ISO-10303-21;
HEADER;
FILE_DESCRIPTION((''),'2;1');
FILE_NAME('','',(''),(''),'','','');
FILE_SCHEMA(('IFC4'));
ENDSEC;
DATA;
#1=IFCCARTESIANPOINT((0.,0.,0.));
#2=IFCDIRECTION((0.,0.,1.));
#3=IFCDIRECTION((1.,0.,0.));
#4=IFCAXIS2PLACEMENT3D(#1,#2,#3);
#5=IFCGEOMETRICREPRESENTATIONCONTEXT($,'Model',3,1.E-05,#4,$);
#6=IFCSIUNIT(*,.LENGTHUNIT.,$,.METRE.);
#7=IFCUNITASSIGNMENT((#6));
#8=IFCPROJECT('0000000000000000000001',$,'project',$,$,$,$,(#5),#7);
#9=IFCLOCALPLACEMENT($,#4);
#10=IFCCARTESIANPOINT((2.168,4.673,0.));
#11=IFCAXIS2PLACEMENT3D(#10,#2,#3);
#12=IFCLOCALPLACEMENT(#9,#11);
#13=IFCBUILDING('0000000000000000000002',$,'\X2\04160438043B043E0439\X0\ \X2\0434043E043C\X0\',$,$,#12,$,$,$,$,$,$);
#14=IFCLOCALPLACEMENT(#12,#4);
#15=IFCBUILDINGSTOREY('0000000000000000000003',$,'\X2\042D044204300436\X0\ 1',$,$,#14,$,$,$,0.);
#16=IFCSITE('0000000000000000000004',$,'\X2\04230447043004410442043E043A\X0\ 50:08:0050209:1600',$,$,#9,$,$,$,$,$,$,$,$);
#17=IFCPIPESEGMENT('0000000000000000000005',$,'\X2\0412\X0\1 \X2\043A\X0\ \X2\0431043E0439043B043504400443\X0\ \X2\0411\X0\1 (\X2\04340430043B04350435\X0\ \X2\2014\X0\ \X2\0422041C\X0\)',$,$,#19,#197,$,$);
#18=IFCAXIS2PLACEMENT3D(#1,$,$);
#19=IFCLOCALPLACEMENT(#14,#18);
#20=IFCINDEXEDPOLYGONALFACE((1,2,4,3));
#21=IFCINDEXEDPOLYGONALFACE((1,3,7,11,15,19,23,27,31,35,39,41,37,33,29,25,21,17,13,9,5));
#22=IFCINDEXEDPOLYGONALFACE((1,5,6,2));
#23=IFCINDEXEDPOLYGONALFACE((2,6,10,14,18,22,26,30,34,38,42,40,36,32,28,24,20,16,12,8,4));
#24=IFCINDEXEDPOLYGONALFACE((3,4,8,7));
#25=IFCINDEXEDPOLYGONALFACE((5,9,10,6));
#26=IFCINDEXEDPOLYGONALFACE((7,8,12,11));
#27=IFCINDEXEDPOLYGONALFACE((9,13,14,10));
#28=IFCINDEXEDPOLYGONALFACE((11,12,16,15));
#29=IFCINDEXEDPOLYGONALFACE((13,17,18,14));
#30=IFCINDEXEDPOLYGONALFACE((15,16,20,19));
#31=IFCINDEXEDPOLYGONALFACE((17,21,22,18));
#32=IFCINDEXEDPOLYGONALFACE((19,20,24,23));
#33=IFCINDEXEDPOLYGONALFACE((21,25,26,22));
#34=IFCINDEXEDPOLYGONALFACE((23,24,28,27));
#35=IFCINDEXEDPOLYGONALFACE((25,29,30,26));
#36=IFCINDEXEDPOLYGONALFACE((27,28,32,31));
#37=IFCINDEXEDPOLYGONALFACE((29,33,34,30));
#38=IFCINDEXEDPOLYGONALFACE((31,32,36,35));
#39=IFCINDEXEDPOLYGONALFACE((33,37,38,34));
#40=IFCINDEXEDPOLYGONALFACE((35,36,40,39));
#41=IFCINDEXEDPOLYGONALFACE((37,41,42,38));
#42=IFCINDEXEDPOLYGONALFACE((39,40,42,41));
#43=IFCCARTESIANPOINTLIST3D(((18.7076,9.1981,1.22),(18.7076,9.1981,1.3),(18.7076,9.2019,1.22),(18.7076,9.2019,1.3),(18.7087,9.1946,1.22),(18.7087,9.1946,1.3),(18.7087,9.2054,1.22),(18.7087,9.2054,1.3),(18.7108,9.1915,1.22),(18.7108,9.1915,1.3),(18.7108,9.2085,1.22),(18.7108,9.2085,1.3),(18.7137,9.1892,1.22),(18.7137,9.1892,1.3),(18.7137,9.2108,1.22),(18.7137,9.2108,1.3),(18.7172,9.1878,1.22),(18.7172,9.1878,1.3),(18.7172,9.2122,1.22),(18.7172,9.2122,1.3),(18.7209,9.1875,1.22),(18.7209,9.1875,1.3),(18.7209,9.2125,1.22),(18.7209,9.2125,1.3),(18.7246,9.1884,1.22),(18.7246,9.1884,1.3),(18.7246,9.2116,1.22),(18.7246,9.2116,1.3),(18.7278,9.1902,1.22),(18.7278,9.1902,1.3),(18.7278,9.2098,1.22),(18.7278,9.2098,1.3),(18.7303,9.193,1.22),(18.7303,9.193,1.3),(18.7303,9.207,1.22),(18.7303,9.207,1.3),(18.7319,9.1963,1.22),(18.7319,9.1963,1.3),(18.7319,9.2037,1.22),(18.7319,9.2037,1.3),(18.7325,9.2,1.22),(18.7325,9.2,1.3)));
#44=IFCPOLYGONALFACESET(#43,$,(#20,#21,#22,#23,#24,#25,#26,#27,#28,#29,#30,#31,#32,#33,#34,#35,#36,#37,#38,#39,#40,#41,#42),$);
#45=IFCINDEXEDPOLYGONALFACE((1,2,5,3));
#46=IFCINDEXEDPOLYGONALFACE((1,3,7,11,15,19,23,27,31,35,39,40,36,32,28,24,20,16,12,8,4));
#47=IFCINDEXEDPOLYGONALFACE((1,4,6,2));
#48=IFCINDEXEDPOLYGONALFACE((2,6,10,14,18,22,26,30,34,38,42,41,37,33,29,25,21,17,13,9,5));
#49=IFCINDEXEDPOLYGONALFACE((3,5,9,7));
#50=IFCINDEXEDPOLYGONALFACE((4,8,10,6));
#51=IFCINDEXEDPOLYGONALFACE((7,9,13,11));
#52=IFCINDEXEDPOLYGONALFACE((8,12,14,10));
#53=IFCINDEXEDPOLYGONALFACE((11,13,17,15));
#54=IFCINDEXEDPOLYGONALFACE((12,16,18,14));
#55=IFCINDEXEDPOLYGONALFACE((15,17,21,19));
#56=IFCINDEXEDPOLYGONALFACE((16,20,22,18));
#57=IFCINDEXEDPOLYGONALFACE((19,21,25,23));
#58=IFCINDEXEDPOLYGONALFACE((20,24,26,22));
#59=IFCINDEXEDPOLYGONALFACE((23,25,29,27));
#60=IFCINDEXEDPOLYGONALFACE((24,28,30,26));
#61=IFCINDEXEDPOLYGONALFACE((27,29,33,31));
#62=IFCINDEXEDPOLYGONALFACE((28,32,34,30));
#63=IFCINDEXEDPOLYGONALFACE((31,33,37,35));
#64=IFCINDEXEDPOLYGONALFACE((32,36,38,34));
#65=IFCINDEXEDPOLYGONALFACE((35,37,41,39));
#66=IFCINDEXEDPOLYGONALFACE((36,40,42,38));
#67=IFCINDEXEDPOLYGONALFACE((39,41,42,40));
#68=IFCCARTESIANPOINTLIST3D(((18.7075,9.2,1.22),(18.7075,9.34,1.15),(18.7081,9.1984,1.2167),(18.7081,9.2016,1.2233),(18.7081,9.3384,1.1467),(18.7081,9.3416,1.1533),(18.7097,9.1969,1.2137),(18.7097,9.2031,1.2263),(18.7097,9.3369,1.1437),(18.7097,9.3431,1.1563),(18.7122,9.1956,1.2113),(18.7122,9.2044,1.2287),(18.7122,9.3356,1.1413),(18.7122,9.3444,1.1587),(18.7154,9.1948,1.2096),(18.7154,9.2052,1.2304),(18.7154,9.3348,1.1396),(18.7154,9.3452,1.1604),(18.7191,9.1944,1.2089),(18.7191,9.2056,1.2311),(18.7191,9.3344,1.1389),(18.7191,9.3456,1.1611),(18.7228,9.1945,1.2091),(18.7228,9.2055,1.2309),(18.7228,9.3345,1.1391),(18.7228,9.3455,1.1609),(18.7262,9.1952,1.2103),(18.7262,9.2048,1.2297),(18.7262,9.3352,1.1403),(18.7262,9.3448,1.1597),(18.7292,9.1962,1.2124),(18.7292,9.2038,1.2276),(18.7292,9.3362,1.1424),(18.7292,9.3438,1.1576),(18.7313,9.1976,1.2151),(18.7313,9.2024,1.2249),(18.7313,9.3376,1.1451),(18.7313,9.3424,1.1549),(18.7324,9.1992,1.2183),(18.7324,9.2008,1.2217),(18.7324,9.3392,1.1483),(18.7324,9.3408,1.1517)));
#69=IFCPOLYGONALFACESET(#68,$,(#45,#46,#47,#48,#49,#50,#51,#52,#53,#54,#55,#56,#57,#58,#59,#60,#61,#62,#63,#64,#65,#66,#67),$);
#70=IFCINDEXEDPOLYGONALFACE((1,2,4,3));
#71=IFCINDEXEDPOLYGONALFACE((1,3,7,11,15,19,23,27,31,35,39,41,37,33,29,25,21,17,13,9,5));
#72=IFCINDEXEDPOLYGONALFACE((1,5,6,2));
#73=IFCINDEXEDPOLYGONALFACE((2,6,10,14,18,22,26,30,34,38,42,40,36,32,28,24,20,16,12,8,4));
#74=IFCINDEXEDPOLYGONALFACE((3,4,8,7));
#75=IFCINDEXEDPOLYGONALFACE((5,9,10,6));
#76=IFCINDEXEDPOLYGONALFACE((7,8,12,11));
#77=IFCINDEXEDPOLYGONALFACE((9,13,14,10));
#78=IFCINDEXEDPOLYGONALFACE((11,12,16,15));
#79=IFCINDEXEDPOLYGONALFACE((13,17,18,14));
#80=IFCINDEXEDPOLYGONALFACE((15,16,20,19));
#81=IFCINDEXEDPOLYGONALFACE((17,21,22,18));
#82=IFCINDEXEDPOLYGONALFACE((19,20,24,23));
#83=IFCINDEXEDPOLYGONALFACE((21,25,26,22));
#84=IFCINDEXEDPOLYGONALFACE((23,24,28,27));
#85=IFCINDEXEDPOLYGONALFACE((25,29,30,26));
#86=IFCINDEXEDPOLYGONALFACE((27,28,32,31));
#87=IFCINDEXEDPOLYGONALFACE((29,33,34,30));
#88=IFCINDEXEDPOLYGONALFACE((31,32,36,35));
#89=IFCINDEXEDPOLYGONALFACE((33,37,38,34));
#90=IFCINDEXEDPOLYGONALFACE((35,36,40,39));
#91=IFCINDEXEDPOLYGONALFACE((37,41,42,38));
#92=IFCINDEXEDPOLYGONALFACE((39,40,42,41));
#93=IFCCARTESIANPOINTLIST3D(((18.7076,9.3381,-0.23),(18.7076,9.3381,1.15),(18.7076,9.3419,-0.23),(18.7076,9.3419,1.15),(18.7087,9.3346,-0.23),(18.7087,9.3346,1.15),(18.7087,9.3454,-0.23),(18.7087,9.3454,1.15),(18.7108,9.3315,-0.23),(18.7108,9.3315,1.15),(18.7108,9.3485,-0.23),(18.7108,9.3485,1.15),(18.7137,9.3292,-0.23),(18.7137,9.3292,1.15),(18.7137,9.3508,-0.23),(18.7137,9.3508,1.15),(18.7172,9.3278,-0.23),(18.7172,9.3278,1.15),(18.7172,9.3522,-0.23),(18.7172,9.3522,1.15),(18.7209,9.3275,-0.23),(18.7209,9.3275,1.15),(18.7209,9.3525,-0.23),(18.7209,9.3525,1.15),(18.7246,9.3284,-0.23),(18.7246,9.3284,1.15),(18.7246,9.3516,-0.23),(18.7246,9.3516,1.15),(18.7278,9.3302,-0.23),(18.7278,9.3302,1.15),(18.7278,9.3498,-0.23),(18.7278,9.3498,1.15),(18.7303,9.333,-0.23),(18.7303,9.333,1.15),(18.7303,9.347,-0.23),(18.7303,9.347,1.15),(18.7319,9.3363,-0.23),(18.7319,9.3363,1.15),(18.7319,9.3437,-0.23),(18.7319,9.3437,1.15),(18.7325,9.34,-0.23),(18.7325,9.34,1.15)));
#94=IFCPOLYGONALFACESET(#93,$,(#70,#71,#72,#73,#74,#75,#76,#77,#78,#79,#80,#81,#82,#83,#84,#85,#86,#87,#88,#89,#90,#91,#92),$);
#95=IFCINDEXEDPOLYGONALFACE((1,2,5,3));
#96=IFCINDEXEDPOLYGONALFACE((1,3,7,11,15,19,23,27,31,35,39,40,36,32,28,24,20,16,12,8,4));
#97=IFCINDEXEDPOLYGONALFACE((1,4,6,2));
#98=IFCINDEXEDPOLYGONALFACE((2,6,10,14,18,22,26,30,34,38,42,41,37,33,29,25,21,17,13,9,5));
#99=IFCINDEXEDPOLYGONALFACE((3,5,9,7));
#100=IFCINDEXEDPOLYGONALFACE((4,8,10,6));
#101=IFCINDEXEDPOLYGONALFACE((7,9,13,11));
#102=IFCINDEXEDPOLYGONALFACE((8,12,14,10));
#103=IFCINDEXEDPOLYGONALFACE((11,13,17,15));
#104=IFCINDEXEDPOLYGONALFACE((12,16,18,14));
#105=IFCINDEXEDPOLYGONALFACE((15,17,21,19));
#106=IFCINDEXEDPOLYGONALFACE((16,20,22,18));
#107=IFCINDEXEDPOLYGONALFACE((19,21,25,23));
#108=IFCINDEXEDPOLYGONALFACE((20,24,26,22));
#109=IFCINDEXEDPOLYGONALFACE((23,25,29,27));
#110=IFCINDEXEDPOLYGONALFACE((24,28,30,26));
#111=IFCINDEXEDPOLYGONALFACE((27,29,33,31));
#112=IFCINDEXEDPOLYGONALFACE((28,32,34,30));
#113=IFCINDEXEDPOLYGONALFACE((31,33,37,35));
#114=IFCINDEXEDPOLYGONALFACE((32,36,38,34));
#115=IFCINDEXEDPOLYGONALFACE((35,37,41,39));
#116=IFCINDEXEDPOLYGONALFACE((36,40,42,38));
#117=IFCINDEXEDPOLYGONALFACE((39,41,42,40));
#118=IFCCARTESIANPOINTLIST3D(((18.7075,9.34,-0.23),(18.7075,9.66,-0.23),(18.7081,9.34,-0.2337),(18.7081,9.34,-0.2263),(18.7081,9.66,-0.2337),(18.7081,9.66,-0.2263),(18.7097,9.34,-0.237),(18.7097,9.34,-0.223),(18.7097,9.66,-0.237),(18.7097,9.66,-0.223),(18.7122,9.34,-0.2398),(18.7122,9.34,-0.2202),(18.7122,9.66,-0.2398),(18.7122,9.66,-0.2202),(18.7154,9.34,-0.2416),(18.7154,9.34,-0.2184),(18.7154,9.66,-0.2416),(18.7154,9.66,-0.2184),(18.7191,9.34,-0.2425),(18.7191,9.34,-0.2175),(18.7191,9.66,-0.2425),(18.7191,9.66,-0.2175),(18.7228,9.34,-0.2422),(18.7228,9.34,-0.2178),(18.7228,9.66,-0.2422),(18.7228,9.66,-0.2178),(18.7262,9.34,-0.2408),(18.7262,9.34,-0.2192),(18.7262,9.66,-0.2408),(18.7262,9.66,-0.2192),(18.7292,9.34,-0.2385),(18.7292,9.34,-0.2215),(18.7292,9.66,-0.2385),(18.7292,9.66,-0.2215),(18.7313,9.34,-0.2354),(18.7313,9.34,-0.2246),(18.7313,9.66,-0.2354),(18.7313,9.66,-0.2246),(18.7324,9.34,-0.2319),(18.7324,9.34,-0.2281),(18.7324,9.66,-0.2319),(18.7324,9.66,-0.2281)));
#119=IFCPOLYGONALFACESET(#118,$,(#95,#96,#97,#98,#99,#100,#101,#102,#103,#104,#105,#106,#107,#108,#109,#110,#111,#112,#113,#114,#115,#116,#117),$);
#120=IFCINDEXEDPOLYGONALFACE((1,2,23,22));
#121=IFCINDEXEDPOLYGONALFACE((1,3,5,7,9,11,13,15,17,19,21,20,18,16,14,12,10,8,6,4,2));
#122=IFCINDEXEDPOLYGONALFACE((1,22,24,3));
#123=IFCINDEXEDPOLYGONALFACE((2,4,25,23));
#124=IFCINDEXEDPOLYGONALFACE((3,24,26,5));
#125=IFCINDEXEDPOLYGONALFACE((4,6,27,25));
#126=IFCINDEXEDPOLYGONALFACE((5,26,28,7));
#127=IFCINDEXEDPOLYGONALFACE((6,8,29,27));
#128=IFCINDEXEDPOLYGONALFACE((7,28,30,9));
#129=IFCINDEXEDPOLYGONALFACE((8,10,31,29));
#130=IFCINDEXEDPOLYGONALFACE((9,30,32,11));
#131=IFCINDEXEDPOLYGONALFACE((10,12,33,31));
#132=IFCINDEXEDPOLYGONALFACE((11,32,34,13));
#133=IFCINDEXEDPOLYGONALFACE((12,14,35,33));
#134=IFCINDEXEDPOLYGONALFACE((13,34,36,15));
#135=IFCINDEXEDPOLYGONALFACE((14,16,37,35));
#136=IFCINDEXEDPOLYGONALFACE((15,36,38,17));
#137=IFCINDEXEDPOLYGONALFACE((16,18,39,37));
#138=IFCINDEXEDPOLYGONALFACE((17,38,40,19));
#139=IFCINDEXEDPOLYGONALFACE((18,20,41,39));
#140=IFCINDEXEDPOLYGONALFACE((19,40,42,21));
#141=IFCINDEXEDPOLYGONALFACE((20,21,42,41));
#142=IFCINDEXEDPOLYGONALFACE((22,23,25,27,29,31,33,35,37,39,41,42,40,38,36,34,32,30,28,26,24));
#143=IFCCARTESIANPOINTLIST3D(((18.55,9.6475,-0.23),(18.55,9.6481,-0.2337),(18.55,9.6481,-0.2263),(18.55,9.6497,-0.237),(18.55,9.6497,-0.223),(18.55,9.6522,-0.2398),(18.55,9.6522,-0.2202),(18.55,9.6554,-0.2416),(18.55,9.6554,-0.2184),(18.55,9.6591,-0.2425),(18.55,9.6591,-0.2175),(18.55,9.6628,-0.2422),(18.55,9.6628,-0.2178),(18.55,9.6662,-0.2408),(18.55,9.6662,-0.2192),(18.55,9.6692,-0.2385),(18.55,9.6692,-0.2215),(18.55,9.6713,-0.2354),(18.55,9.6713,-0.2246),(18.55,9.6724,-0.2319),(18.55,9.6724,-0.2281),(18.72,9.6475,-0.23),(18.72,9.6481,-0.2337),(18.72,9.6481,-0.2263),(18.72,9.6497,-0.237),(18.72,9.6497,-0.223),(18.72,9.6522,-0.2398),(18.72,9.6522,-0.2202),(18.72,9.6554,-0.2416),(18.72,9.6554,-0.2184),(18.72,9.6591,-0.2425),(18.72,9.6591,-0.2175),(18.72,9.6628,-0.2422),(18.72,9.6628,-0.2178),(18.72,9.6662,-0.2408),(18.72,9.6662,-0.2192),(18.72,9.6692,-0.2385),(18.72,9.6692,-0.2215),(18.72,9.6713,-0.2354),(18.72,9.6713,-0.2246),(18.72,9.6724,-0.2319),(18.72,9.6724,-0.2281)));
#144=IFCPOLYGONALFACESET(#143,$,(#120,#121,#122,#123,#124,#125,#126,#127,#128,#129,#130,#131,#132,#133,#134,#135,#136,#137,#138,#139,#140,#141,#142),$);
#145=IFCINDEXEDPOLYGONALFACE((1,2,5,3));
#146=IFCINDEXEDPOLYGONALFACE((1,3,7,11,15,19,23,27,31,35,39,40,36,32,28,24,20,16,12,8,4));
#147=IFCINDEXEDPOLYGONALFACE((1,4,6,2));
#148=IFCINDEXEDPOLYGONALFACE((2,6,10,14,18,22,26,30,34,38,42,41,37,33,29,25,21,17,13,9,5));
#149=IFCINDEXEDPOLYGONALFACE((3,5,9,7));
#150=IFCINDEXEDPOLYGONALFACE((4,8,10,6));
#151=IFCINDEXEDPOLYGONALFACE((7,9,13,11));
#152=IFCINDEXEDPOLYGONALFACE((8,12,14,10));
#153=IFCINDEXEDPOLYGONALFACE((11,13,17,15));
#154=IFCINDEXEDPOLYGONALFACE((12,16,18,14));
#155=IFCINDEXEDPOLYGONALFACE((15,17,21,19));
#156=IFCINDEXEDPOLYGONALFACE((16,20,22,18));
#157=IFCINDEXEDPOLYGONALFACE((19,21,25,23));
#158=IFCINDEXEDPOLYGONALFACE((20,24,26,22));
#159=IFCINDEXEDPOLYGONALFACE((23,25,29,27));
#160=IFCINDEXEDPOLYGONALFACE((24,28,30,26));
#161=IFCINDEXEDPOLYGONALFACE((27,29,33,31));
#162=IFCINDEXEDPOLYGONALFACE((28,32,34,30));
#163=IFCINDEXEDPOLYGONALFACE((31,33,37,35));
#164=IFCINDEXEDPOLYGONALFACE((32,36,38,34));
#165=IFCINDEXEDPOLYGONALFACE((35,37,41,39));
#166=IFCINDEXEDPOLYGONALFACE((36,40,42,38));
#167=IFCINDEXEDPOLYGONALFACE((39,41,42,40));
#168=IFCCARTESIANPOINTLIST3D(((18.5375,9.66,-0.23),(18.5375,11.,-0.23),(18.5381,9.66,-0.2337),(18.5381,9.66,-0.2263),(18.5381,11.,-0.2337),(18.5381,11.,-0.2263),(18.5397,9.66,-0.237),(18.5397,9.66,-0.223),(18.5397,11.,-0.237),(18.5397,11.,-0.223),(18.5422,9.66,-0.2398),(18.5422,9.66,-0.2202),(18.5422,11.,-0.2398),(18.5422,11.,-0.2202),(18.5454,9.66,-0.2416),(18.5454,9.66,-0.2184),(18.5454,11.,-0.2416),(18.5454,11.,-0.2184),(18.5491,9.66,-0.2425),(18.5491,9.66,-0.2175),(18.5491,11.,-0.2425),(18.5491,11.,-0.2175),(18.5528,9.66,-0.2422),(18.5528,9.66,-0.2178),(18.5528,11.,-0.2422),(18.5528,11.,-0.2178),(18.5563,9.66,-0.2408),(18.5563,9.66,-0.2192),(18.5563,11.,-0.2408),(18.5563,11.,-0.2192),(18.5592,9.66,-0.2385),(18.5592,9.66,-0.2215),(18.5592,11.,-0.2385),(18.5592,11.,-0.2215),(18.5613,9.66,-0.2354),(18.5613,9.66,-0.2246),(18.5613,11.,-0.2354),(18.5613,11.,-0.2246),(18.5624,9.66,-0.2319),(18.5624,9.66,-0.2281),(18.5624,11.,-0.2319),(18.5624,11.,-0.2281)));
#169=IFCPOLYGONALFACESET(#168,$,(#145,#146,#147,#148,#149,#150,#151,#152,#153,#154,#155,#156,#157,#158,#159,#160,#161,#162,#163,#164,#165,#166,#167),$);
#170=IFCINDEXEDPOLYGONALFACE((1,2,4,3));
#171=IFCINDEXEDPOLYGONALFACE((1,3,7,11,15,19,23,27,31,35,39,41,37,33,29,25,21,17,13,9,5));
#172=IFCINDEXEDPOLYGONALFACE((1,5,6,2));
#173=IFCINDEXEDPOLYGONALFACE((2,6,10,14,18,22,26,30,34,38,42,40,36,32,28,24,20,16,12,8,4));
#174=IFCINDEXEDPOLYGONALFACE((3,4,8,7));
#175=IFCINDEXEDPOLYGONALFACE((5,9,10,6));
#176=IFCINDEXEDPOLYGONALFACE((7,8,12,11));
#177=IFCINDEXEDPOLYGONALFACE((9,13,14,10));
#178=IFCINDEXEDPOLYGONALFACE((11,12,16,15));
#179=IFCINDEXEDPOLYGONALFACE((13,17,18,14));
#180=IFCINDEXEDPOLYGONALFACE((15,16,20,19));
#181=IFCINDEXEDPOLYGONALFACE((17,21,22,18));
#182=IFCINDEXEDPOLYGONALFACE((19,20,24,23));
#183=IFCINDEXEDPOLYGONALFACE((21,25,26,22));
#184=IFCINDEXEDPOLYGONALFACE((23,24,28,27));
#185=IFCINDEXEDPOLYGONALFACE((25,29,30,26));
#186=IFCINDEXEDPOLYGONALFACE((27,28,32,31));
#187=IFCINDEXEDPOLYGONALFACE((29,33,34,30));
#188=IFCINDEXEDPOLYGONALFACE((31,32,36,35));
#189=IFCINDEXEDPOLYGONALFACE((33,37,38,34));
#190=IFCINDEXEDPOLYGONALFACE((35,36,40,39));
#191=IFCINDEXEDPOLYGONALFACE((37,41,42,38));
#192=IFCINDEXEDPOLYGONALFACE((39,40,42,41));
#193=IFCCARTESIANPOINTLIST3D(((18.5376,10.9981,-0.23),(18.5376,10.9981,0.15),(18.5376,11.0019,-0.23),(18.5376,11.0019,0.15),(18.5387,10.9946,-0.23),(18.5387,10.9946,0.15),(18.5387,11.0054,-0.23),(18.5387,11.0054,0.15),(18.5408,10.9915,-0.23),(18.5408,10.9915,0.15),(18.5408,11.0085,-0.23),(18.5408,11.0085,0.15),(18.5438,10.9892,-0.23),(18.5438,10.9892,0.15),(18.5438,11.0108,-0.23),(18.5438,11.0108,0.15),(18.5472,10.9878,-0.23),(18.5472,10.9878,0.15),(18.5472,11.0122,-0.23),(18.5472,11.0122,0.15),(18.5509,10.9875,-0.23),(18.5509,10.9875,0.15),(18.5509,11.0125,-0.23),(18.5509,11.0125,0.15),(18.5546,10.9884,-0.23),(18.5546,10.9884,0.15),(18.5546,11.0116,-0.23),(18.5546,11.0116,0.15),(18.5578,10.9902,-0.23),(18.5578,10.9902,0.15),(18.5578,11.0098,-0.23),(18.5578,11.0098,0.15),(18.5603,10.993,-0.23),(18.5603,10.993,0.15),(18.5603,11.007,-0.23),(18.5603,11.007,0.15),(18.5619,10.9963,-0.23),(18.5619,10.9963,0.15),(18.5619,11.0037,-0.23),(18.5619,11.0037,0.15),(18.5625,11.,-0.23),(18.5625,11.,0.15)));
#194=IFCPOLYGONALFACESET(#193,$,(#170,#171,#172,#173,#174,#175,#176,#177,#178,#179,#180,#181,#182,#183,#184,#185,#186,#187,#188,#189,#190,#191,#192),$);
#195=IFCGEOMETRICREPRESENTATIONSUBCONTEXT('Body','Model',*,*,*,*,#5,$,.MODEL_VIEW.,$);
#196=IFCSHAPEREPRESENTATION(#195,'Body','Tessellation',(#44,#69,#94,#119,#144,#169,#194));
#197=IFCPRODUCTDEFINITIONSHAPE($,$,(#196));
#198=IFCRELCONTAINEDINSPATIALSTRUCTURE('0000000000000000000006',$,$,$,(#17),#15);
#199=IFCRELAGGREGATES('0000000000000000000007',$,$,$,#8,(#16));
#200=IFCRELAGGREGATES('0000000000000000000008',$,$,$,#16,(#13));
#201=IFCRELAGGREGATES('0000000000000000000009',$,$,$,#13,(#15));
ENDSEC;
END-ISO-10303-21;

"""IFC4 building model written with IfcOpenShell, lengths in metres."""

from ifc_helpers import new_model, si_unit, frame, origin_with_axes, origin_2d, place, context, subcontext, project, spatial, circle, extrude, element, save


model = new_model("IFC4")

# Units and contexts
model_context = context("Model", 3, precision=1e-05, world=origin_with_axes())
body_context = subcontext(model_context, "Body", "Model", "MODEL_VIEW")
ifc_project = project(units=[si_unit("LENGTHUNIT", "METRE")], contexts=[model_context])

# Site, building, storey
site_placement = place(None, origin_with_axes())
site = spatial("IfcSite", under=ifc_project, at=site_placement, Name="Участок 50:08:0050209:1600")
building_placement = place(site_placement, frame((2.168, 4.673, 0.0), z_axis=(0.0, 0.0, 1.0), x_axis=(1.0, 0.0, 0.0)))
building = spatial("IfcBuilding", under=site, at=building_placement, Name="Жилой дом")
storey_placement = place(building_placement, origin_with_axes())
storey = spatial("IfcBuildingStorey", under=building, at=storey_placement, Name="Этаж 1", Elevation=0.0)

# Pipe segment
pipe_segment_1_placement = place(storey_placement, origin_with_axes())
element("IfcPipeSegment", 1, at=pipe_segment_1_placement, inside=storey, Name="В1 к бойлеру Б1 (далее — ТМ)", context=body_context, shape_type="SweptSolid", body=[
    extrude(circle(Radius=0.0125, at=origin_2d()), frame((18.72, 9.2, 1.3), z_axis=(0.0, 0.0, -1.0), x_axis=(1.0, 0.0, 0.0)), (0.0, 0.0, 1.0), 0.08),
    extrude(circle(Radius=0.0125, at=origin_2d()), frame((18.72, 9.2, 1.22), z_axis=(0.0, 0.894427, -0.447214), x_axis=(-1.0, 0.0, 0.0)), (0.0, 0.0, 1.0), 0.1565),
    extrude(circle(Radius=0.0125, at=origin_2d()), frame((18.72, 9.34, 1.15), z_axis=(0.0, 0.0, -1.0), x_axis=(1.0, 0.0, 0.0)), (0.0, 0.0, 1.0), 1.38),
    extrude(circle(Radius=0.0125, at=origin_2d()), frame((18.72, 9.34, -0.23), z_axis=(0.0, 1.0, 0.0), x_axis=(-1.0, 0.0, 0.0)), (0.0, 0.0, 1.0), 0.32),
    extrude(circle(Radius=0.0125, at=origin_2d()), frame((18.72, 9.66, -0.23), z_axis=(-1.0, 0.0, 0.0), x_axis=(0.0, -1.0, 0.0)), (0.0, 0.0, 1.0), 0.17),
    extrude(circle(Radius=0.0125, at=origin_2d()), frame((18.55, 9.66, -0.23), z_axis=(0.0, 1.0, 0.0), x_axis=(-1.0, 0.0, 0.0)), (0.0, 0.0, 1.0), 1.34),
    extrude(circle(Radius=0.0125, at=origin_2d()), frame((18.55, 11.0, -0.23), z_axis=(0.0, 0.0, 1.0), x_axis=(1.0, 0.0, 0.0)), (0.0, 0.0, 1.0), 0.38),
])

save(model, "model.ifc")
